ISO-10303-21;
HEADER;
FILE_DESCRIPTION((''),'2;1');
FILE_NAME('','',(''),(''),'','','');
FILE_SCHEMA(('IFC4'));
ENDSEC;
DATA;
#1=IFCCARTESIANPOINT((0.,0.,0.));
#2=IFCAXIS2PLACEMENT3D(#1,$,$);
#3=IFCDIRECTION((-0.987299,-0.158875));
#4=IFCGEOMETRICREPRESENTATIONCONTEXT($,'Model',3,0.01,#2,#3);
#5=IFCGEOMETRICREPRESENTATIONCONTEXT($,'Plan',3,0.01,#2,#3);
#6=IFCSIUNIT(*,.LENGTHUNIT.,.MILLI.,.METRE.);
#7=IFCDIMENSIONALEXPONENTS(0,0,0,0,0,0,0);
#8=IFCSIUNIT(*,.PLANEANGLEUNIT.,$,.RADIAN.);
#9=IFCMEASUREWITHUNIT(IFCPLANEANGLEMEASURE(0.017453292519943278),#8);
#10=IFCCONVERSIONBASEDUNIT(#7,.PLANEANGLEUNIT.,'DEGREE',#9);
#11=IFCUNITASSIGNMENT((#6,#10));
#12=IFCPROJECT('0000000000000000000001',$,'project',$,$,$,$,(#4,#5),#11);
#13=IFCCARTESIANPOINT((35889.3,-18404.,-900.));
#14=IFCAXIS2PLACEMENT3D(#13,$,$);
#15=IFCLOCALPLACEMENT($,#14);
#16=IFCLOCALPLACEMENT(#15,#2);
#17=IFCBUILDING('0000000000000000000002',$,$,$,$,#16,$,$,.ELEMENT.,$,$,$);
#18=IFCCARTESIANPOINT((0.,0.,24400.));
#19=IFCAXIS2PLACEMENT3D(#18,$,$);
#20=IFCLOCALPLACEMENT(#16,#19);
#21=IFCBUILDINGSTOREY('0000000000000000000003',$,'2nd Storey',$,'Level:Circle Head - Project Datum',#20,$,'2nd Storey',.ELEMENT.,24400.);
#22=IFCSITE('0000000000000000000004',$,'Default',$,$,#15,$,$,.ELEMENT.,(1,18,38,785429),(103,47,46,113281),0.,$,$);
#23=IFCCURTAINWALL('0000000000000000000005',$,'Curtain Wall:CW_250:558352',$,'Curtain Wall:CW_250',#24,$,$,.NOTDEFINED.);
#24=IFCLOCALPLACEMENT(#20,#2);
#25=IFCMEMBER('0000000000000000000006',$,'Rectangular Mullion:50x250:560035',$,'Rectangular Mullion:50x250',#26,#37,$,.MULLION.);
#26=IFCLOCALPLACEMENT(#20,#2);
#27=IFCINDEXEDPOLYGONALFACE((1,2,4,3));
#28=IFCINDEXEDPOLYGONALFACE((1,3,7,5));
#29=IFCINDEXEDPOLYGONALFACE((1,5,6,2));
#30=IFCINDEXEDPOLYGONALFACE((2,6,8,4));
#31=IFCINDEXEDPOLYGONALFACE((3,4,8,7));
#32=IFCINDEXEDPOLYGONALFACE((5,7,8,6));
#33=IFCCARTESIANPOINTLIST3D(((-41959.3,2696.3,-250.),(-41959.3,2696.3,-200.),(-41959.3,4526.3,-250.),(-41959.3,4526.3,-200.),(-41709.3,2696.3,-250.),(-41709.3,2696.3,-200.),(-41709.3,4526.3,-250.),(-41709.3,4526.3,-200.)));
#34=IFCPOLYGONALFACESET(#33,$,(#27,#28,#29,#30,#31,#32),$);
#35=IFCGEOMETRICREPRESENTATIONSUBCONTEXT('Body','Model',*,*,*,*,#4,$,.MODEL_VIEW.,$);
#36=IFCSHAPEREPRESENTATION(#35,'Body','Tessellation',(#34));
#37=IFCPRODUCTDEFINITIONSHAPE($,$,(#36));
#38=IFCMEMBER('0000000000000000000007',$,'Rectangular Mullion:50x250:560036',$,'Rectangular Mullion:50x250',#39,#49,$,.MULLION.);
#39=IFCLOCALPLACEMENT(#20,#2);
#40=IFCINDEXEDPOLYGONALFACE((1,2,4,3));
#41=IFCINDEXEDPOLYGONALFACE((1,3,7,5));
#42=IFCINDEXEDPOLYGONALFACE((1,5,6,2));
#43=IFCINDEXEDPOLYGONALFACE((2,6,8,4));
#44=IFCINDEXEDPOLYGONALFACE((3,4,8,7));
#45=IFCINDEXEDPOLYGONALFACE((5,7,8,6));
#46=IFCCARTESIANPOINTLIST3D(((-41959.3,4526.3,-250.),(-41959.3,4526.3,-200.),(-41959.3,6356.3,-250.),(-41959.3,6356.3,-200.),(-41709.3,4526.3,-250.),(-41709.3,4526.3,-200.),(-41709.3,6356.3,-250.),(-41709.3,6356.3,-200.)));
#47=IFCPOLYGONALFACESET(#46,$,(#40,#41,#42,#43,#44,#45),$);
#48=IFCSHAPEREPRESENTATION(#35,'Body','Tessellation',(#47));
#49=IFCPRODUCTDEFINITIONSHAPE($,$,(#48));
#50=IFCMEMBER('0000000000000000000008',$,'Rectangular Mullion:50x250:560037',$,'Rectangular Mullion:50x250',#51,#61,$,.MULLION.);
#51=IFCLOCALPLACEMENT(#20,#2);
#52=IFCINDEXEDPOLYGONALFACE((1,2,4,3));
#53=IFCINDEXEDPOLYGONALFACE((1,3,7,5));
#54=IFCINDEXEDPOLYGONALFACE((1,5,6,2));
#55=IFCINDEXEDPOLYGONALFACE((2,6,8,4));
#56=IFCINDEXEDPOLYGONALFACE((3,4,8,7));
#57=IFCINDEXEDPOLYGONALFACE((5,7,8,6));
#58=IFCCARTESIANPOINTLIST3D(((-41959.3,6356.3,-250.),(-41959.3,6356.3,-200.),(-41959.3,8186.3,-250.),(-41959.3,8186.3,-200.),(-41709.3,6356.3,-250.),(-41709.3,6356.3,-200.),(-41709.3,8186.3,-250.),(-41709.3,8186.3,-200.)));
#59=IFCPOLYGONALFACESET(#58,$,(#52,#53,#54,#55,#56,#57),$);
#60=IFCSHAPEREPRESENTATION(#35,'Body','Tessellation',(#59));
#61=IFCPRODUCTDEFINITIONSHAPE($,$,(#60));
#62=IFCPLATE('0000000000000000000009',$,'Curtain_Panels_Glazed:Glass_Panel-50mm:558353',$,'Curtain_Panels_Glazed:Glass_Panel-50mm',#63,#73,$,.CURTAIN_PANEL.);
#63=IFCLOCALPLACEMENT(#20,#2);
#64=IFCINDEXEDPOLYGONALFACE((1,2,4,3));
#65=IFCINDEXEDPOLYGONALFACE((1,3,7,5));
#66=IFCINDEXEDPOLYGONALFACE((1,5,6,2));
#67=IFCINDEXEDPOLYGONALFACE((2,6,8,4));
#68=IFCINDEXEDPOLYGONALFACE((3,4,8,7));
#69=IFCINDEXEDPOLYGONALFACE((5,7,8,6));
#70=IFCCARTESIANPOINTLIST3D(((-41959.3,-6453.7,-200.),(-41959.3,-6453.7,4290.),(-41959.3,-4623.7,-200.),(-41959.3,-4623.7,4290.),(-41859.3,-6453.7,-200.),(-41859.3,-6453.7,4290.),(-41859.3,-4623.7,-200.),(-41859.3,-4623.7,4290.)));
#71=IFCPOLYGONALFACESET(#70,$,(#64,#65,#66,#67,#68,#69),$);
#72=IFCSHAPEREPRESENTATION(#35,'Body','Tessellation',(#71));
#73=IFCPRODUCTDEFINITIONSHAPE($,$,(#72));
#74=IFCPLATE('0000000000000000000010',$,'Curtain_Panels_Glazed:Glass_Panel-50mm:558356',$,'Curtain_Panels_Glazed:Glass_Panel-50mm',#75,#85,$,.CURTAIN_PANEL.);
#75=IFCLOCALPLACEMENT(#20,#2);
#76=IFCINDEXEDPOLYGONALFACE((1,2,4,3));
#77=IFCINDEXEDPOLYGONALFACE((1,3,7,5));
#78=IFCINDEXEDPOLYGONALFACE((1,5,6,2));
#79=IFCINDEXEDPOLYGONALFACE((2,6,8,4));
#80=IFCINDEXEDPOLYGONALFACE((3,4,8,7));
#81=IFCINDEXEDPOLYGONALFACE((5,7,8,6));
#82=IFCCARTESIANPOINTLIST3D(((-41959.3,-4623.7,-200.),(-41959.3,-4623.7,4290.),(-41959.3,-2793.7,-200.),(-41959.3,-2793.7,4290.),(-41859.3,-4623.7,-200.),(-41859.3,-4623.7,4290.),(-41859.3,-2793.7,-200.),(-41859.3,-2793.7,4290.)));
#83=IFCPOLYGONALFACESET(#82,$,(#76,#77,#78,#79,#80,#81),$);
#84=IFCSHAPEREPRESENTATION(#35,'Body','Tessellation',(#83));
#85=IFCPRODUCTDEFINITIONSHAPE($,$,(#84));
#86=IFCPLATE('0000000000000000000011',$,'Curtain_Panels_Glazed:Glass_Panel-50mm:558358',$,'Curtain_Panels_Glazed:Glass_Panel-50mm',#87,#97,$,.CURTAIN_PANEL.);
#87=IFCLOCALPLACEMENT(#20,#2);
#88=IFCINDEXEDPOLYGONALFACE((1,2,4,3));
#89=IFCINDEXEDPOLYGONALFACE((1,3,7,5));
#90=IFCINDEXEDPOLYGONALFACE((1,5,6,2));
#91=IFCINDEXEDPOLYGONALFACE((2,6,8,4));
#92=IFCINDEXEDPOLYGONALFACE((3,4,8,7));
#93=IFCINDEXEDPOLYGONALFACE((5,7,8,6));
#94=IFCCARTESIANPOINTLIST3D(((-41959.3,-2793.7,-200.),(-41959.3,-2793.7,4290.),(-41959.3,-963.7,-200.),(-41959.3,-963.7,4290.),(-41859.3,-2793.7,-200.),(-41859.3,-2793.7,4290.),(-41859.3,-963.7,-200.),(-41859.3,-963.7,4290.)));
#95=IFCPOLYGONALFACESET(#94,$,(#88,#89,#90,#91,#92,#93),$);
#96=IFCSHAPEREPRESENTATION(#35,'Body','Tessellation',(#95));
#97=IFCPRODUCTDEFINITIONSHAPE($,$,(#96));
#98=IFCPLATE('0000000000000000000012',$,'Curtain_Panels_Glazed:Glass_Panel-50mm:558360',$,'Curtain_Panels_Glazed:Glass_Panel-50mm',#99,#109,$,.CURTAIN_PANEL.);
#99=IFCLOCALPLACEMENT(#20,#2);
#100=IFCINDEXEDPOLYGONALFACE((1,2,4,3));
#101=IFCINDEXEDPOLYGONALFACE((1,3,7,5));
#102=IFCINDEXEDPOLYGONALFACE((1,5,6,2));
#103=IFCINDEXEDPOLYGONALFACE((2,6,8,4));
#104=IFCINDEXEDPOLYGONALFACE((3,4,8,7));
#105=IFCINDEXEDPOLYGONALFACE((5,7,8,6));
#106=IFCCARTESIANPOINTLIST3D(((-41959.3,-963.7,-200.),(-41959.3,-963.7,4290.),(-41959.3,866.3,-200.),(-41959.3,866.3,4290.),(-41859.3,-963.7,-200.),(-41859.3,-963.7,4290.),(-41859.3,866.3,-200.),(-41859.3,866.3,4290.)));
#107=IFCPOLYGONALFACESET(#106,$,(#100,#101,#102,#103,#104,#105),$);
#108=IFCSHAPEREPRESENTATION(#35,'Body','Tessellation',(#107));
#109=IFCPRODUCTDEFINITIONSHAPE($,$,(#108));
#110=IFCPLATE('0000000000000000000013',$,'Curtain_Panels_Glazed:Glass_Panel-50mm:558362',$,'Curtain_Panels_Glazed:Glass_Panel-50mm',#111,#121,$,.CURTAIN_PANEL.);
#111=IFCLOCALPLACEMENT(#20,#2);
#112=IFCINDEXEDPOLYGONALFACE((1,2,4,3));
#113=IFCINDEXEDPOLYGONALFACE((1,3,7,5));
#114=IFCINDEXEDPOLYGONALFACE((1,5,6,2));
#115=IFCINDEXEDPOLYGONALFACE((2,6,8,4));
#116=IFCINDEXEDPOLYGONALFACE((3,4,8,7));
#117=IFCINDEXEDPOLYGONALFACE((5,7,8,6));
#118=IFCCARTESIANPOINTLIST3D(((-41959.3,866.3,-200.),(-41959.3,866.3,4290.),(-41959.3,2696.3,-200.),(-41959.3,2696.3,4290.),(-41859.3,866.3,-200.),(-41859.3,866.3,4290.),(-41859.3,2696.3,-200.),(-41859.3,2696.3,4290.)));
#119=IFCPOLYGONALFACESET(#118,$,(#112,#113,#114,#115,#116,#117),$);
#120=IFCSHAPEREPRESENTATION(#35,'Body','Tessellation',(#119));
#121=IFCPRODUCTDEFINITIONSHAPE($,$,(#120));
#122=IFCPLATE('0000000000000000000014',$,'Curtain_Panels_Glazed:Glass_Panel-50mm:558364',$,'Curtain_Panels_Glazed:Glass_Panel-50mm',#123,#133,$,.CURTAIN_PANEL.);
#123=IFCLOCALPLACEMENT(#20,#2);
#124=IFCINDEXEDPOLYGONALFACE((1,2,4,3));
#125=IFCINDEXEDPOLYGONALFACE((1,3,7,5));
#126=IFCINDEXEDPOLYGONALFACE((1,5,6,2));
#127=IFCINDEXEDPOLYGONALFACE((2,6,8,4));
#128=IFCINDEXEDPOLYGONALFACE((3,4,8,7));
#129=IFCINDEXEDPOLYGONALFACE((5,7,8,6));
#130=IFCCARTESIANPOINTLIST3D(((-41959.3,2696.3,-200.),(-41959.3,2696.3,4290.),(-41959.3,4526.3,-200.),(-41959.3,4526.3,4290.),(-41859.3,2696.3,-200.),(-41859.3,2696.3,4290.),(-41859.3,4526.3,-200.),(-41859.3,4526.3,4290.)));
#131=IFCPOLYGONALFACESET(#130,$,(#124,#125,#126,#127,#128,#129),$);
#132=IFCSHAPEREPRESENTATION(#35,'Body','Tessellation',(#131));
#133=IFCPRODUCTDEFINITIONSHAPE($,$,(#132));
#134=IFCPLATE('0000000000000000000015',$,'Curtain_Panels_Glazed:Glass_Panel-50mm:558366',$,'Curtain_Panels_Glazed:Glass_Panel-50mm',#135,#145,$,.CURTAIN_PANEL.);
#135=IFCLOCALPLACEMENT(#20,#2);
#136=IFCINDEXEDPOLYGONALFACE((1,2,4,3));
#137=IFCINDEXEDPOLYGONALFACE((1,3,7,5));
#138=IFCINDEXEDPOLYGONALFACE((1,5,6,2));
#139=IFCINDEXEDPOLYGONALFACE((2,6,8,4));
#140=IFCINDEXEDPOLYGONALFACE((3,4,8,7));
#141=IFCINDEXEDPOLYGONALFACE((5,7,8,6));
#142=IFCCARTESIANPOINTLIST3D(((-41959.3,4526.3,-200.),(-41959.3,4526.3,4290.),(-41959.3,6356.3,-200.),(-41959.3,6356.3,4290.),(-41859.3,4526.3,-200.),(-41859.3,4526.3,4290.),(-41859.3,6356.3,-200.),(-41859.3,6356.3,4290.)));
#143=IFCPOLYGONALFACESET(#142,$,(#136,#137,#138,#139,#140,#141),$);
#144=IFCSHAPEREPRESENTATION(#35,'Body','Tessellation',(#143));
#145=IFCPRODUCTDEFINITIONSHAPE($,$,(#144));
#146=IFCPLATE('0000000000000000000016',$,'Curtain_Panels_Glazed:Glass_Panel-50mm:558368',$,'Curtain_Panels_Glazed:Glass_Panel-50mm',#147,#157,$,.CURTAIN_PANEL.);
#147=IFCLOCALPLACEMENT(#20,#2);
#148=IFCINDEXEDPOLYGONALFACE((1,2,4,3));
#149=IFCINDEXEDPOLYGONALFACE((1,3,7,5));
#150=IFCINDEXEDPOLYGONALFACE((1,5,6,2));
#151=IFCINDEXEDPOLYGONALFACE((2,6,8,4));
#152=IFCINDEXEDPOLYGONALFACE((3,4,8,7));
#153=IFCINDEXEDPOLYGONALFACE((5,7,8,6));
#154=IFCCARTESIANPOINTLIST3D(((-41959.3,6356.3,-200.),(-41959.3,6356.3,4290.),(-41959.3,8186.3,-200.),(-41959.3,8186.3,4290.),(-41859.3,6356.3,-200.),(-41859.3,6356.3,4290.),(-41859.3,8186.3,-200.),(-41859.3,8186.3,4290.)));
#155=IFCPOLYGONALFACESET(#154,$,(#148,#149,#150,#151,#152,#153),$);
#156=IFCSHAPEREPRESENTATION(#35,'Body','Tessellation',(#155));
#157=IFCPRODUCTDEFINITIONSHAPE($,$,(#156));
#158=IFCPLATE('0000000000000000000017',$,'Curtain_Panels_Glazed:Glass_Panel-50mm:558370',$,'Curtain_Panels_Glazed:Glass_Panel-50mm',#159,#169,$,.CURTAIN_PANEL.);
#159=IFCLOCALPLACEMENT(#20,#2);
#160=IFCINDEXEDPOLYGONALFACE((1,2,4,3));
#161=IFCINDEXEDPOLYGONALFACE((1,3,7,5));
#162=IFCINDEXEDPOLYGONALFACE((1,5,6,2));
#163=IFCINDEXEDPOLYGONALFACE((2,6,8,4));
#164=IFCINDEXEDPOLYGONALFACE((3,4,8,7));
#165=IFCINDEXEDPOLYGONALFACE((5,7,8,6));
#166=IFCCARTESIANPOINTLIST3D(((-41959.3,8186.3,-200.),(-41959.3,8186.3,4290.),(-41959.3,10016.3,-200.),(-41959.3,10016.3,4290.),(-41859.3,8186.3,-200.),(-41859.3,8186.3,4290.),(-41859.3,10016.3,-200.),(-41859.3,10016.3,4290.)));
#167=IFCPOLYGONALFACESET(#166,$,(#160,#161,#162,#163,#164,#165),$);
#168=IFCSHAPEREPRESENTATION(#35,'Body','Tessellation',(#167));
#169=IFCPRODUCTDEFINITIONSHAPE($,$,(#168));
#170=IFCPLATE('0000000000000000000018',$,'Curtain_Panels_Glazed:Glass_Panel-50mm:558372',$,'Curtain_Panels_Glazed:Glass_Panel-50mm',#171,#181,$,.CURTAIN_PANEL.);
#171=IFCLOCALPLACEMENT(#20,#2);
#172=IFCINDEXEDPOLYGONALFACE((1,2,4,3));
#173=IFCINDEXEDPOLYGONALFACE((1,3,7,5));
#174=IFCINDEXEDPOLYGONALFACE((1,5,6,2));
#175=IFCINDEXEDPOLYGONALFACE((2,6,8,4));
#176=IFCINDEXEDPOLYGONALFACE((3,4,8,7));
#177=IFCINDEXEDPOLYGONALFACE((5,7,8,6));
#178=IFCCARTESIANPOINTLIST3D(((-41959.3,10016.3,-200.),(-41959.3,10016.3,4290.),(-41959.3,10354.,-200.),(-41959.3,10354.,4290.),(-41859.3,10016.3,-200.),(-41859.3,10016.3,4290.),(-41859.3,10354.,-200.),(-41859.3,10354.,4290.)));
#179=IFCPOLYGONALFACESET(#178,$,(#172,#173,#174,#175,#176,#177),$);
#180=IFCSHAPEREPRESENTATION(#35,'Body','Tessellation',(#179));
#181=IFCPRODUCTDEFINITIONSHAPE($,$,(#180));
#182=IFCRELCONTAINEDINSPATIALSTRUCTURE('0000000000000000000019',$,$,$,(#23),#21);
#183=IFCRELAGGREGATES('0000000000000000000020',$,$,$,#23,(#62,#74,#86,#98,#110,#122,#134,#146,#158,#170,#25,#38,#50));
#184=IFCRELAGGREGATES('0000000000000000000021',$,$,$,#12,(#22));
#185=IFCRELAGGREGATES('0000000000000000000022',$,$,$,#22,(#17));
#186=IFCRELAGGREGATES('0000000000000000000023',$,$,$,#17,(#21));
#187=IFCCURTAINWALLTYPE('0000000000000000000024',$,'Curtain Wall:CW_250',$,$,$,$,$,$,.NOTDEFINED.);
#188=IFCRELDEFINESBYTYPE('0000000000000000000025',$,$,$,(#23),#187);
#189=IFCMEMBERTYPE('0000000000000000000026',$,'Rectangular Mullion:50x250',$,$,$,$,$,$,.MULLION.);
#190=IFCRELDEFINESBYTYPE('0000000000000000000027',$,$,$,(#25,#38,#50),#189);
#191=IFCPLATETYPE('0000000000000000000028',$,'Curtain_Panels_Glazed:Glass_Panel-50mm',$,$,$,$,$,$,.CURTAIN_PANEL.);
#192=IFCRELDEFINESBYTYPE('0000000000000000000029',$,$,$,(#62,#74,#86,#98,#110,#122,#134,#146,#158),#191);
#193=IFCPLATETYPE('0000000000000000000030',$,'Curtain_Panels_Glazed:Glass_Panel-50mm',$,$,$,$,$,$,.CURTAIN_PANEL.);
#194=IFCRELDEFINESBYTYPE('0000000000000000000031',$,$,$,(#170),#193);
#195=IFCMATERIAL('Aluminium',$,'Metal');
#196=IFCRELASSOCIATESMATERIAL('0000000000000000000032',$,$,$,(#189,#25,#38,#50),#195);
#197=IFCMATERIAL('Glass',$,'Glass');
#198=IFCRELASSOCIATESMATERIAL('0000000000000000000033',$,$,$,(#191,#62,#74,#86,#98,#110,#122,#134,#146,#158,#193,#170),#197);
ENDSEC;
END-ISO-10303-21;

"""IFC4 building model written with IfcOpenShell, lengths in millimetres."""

from ifc_helpers import new_model, entity, si_unit, converted_unit, direction, frame, origin, place, context, subcontext, project, spatial, indexed_curve, outline, extrude, source, transform, mapped, material, type_object, type_shapes, element, aggregate, save


model = new_model("IFC4")

# Units and contexts
model_context = context("Model", 3, precision=0.01, world=origin(), true_north=direction((-0.987299, -0.158875)))
plan_context = context("Plan", 3, precision=0.01, world=origin(), true_north=direction((-0.987299, -0.158875)))
body_context = subcontext(model_context, "Body", "Model", "MODEL_VIEW")
ifc_project = project(units=[si_unit("LENGTHUNIT", "METRE", prefix="MILLI"), converted_unit("PLANEANGLEUNIT", "DEGREE", entity("IfcPlaneAngleMeasure", 0.017453292519943278), si_unit("PLANEANGLEUNIT", "RADIAN"), dimensions=[0, 0, 0, 0, 0, 0, 0])], contexts=[model_context, plan_context])

# Site, building, storey
site_placement = place(None, frame((35889.3, -18404.0, -900.0)))
site = spatial("IfcSite", under=ifc_project, at=site_placement, Name="Default", CompositionType="ELEMENT", RefLatitude=(1, 18, 38, 785429), RefLongitude=(103, 47, 46, 113281), RefElevation=0.0)
building_placement = place(site_placement, origin())
building = spatial("IfcBuilding", under=site, at=building_placement, CompositionType="ELEMENT")
storey_placement = place(building_placement, frame((0.0, 0.0, 24400.0)))
storey = spatial("IfcBuildingStorey", under=building, at=storey_placement, Name="2nd Storey", ObjectType="Level:Circle Head - Project Datum", LongName="2nd Storey", CompositionType="ELEMENT", Elevation=24400.0)

# Curtain wall, members
curtain_wall_type = type_object("IfcCurtainWallType", Name="Curtain Wall:CW_250", PredefinedType="NOTDEFINED")
curtain_wall_1_placement = place(storey_placement, frame((0.0, 0.0, -24400.0)))
curtain_wall_1 = element("IfcCurtainWall", 1, at=curtain_wall_1_placement, inside=storey, type_object=curtain_wall_type, Name="Curtain Wall:CW_250:558352", ObjectType="Curtain Wall:CW_250", PredefinedType="NOTDEFINED")
ifc_material_1 = material(Name="Aluminium", Category="Metal")
member_type_1 = type_object("IfcMemberType", Name="Rectangular Mullion:50x250", PredefinedType="MULLION", material=ifc_material_1)
shared_shape_1 = source(origin(), body_context, "Body", "SweptSolid", [
    extrude(outline(indexed_curve([(-25.0, -125.0), (25.0, -125.0), (25.0, 125.0), (-25.0, 125.0), (-25.0, -125.0)], self_intersect=False)), frame((-25.0, -125.0, -1830.0), z_axis=(0.0, 0.0, 1.0), x_axis=(-1.0, 0.0, 0.0)), (0.0, 0.0, 1.0), 1830.0),
])
type_shapes(member_type_1, [shared_shape_1])
member_1_placement = place(curtain_wall_1_placement, frame((-41709.3, 2696.3, 24150.0), z_axis=(0.0, -1.0, 0.0), x_axis=(0.0, 0.0, -1.0)))
member_1 = element("IfcMember", 2, at=member_1_placement, type_object=member_type_1, material=ifc_material_1, Name="Rectangular Mullion:50x250:560035", ObjectType="Rectangular Mullion:50x250", PredefinedType="MULLION", context=body_context, shape_type="MappedRepresentation", body=[
    mapped(shared_shape_1, transform((0.0, 0.0, 0.0), scale=1.0)),
])
member_2_placement = place(curtain_wall_1_placement, frame((-41709.3, 4526.3, 24150.0), z_axis=(0.0, -1.0, 0.0), x_axis=(0.0, 0.0, -1.0)))
member_2 = element("IfcMember", 3, at=member_2_placement, type_object=member_type_1, material=ifc_material_1, Name="Rectangular Mullion:50x250:560036", ObjectType="Rectangular Mullion:50x250", PredefinedType="MULLION", context=body_context, shape_type="MappedRepresentation", body=[
    mapped(shared_shape_1, transform((0.0, 0.0, 0.0), scale=1.0)),
])
member_3_placement = place(curtain_wall_1_placement, frame((-41709.3, 6356.3, 24150.0), z_axis=(0.0, -1.0, 0.0), x_axis=(0.0, 0.0, -1.0)))
member_3 = element("IfcMember", 4, at=member_3_placement, type_object=member_type_1, material=ifc_material_1, Name="Rectangular Mullion:50x250:560037", ObjectType="Rectangular Mullion:50x250", PredefinedType="MULLION", context=body_context, shape_type="MappedRepresentation", body=[
    mapped(shared_shape_1, transform((0.0, 0.0, 0.0), scale=1.0)),
])

# Plates
ifc_material_2 = material(Name="Glass", Category="Glass")
plate_type_1 = type_object("IfcPlateType", Name="Curtain_Panels_Glazed:Glass_Panel-50mm", PredefinedType="CURTAIN_PANEL", material=ifc_material_2)
shared_shape_2 = source(origin(), body_context, "Body", "SweptSolid", [
    extrude(outline(indexed_curve([(-50.0, -915.0), (50.0, -915.0), (50.0, 915.0), (-50.0, 915.0), (-50.0, -915.0)], self_intersect=False)), frame((0.0, 200.0, 0.0), z_axis=(0.0, 0.0, 1.0), x_axis=(0.0, 1.0, 0.0)), (0.0, 0.0, 1.0), 4490.0),
])
type_shapes(plate_type_1, [shared_shape_2])
plate_1_placement = place(curtain_wall_1_placement, frame((-41709.3, -5538.7, 24200.0), z_axis=(0.0, 0.0, 1.0), x_axis=(0.0, 1.0, 0.0)))
plate_1 = element("IfcPlate", 5, at=plate_1_placement, type_object=plate_type_1, material=ifc_material_2, Name="Curtain_Panels_Glazed:Glass_Panel-50mm:558353", ObjectType="Curtain_Panels_Glazed:Glass_Panel-50mm", PredefinedType="CURTAIN_PANEL", context=body_context, shape_type="MappedRepresentation", body=[
    mapped(shared_shape_2, transform((0.0, 0.0, 0.0), scale=1.0)),
])
plate_2_placement = place(curtain_wall_1_placement, frame((-41709.3, -3708.7, 24200.0), z_axis=(0.0, 0.0, 1.0), x_axis=(0.0, 1.0, 0.0)))
plate_2 = element("IfcPlate", 6, at=plate_2_placement, type_object=plate_type_1, material=ifc_material_2, Name="Curtain_Panels_Glazed:Glass_Panel-50mm:558356", ObjectType="Curtain_Panels_Glazed:Glass_Panel-50mm", PredefinedType="CURTAIN_PANEL", context=body_context, shape_type="MappedRepresentation", body=[
    mapped(shared_shape_2, transform((0.0, 0.0, 0.0), scale=1.0)),
])
plate_3_placement = place(curtain_wall_1_placement, frame((-41709.3, -1878.7, 24200.0), z_axis=(0.0, 0.0, 1.0), x_axis=(0.0, 1.0, 0.0)))
plate_3 = element("IfcPlate", 7, at=plate_3_placement, type_object=plate_type_1, material=ifc_material_2, Name="Curtain_Panels_Glazed:Glass_Panel-50mm:558358", ObjectType="Curtain_Panels_Glazed:Glass_Panel-50mm", PredefinedType="CURTAIN_PANEL", context=body_context, shape_type="MappedRepresentation", body=[
    mapped(shared_shape_2, transform((0.0, 0.0, 0.0), scale=1.0)),
])
plate_4_placement = place(curtain_wall_1_placement, frame((-41709.3, -48.7, 24200.0), z_axis=(0.0, 0.0, 1.0), x_axis=(0.0, 1.0, 0.0)))
plate_4 = element("IfcPlate", 8, at=plate_4_placement, type_object=plate_type_1, material=ifc_material_2, Name="Curtain_Panels_Glazed:Glass_Panel-50mm:558360", ObjectType="Curtain_Panels_Glazed:Glass_Panel-50mm", PredefinedType="CURTAIN_PANEL", context=body_context, shape_type="MappedRepresentation", body=[
    mapped(shared_shape_2, transform((0.0, 0.0, 0.0), scale=1.0)),
])
plate_5_placement = place(curtain_wall_1_placement, frame((-41709.3, 1781.3, 24200.0), z_axis=(0.0, 0.0, 1.0), x_axis=(0.0, 1.0, 0.0)))
plate_5 = element("IfcPlate", 9, at=plate_5_placement, type_object=plate_type_1, material=ifc_material_2, Name="Curtain_Panels_Glazed:Glass_Panel-50mm:558362", ObjectType="Curtain_Panels_Glazed:Glass_Panel-50mm", PredefinedType="CURTAIN_PANEL", context=body_context, shape_type="MappedRepresentation", body=[
    mapped(shared_shape_2, transform((0.0, 0.0, 0.0), scale=1.0)),
])
plate_6_placement = place(curtain_wall_1_placement, frame((-41709.3, 3611.3, 24200.0), z_axis=(0.0, 0.0, 1.0), x_axis=(0.0, 1.0, 0.0)))
plate_6 = element("IfcPlate", 10, at=plate_6_placement, type_object=plate_type_1, material=ifc_material_2, Name="Curtain_Panels_Glazed:Glass_Panel-50mm:558364", ObjectType="Curtain_Panels_Glazed:Glass_Panel-50mm", PredefinedType="CURTAIN_PANEL", context=body_context, shape_type="MappedRepresentation", body=[
    mapped(shared_shape_2, transform((0.0, 0.0, 0.0), scale=1.0)),
])
plate_7_placement = place(curtain_wall_1_placement, frame((-41709.3, 5441.3, 24200.0), z_axis=(0.0, 0.0, 1.0), x_axis=(0.0, 1.0, 0.0)))
plate_7 = element("IfcPlate", 11, at=plate_7_placement, type_object=plate_type_1, material=ifc_material_2, Name="Curtain_Panels_Glazed:Glass_Panel-50mm:558366", ObjectType="Curtain_Panels_Glazed:Glass_Panel-50mm", PredefinedType="CURTAIN_PANEL", context=body_context, shape_type="MappedRepresentation", body=[
    mapped(shared_shape_2, transform((0.0, 0.0, 0.0), scale=1.0)),
])
plate_8_placement = place(curtain_wall_1_placement, frame((-41709.3, 7271.3, 24200.0), z_axis=(0.0, 0.0, 1.0), x_axis=(0.0, 1.0, 0.0)))
plate_8 = element("IfcPlate", 12, at=plate_8_placement, type_object=plate_type_1, material=ifc_material_2, Name="Curtain_Panels_Glazed:Glass_Panel-50mm:558368", ObjectType="Curtain_Panels_Glazed:Glass_Panel-50mm", PredefinedType="CURTAIN_PANEL", context=body_context, shape_type="MappedRepresentation", body=[
    mapped(shared_shape_2, transform((0.0, 0.0, 0.0), scale=1.0)),
])
plate_9_placement = place(curtain_wall_1_placement, frame((-41709.3, 9101.3, 24200.0), z_axis=(0.0, 0.0, 1.0), x_axis=(0.0, 1.0, 0.0)))
plate_9 = element("IfcPlate", 13, at=plate_9_placement, type_object=plate_type_1, material=ifc_material_2, Name="Curtain_Panels_Glazed:Glass_Panel-50mm:558370", ObjectType="Curtain_Panels_Glazed:Glass_Panel-50mm", PredefinedType="CURTAIN_PANEL", context=body_context, shape_type="MappedRepresentation", body=[
    mapped(shared_shape_2, transform((0.0, 0.0, 0.0), scale=1.0)),
])
plate_type_2 = type_object("IfcPlateType", Name="Curtain_Panels_Glazed:Glass_Panel-50mm", PredefinedType="CURTAIN_PANEL", material=ifc_material_2)
shared_shape_3 = source(origin(), body_context, "Body", "SweptSolid", [
    extrude(outline(indexed_curve([(-50.0, -168.9), (50.0, -168.9), (50.0, 168.9), (-50.0, 168.9), (-50.0, -168.9)], self_intersect=False)), frame((0.0, 200.0, 0.0), z_axis=(0.0, 0.0, 1.0), x_axis=(0.0, 1.0, 0.0)), (0.0, 0.0, 1.0), 4490.0),
])
type_shapes(plate_type_2, [shared_shape_3])
plate_10_placement = place(curtain_wall_1_placement, frame((-41709.3, 10185.2, 24200.0), z_axis=(0.0, 0.0, 1.0), x_axis=(0.0, 1.0, 0.0)))
plate_10 = element("IfcPlate", 14, at=plate_10_placement, type_object=plate_type_2, material=ifc_material_2, Name="Curtain_Panels_Glazed:Glass_Panel-50mm:558372", ObjectType="Curtain_Panels_Glazed:Glass_Panel-50mm", PredefinedType="CURTAIN_PANEL", context=body_context, shape_type="MappedRepresentation", body=[
    mapped(shared_shape_3, transform((0.0, 0.0, 0.0), scale=1.0)),
])
aggregate(curtain_wall_1, [plate_1, plate_2, plate_3, plate_4, plate_5, plate_6, plate_7, plate_8, plate_9, plate_10, member_1, member_2, member_3])

save(model, "model.ifc")
